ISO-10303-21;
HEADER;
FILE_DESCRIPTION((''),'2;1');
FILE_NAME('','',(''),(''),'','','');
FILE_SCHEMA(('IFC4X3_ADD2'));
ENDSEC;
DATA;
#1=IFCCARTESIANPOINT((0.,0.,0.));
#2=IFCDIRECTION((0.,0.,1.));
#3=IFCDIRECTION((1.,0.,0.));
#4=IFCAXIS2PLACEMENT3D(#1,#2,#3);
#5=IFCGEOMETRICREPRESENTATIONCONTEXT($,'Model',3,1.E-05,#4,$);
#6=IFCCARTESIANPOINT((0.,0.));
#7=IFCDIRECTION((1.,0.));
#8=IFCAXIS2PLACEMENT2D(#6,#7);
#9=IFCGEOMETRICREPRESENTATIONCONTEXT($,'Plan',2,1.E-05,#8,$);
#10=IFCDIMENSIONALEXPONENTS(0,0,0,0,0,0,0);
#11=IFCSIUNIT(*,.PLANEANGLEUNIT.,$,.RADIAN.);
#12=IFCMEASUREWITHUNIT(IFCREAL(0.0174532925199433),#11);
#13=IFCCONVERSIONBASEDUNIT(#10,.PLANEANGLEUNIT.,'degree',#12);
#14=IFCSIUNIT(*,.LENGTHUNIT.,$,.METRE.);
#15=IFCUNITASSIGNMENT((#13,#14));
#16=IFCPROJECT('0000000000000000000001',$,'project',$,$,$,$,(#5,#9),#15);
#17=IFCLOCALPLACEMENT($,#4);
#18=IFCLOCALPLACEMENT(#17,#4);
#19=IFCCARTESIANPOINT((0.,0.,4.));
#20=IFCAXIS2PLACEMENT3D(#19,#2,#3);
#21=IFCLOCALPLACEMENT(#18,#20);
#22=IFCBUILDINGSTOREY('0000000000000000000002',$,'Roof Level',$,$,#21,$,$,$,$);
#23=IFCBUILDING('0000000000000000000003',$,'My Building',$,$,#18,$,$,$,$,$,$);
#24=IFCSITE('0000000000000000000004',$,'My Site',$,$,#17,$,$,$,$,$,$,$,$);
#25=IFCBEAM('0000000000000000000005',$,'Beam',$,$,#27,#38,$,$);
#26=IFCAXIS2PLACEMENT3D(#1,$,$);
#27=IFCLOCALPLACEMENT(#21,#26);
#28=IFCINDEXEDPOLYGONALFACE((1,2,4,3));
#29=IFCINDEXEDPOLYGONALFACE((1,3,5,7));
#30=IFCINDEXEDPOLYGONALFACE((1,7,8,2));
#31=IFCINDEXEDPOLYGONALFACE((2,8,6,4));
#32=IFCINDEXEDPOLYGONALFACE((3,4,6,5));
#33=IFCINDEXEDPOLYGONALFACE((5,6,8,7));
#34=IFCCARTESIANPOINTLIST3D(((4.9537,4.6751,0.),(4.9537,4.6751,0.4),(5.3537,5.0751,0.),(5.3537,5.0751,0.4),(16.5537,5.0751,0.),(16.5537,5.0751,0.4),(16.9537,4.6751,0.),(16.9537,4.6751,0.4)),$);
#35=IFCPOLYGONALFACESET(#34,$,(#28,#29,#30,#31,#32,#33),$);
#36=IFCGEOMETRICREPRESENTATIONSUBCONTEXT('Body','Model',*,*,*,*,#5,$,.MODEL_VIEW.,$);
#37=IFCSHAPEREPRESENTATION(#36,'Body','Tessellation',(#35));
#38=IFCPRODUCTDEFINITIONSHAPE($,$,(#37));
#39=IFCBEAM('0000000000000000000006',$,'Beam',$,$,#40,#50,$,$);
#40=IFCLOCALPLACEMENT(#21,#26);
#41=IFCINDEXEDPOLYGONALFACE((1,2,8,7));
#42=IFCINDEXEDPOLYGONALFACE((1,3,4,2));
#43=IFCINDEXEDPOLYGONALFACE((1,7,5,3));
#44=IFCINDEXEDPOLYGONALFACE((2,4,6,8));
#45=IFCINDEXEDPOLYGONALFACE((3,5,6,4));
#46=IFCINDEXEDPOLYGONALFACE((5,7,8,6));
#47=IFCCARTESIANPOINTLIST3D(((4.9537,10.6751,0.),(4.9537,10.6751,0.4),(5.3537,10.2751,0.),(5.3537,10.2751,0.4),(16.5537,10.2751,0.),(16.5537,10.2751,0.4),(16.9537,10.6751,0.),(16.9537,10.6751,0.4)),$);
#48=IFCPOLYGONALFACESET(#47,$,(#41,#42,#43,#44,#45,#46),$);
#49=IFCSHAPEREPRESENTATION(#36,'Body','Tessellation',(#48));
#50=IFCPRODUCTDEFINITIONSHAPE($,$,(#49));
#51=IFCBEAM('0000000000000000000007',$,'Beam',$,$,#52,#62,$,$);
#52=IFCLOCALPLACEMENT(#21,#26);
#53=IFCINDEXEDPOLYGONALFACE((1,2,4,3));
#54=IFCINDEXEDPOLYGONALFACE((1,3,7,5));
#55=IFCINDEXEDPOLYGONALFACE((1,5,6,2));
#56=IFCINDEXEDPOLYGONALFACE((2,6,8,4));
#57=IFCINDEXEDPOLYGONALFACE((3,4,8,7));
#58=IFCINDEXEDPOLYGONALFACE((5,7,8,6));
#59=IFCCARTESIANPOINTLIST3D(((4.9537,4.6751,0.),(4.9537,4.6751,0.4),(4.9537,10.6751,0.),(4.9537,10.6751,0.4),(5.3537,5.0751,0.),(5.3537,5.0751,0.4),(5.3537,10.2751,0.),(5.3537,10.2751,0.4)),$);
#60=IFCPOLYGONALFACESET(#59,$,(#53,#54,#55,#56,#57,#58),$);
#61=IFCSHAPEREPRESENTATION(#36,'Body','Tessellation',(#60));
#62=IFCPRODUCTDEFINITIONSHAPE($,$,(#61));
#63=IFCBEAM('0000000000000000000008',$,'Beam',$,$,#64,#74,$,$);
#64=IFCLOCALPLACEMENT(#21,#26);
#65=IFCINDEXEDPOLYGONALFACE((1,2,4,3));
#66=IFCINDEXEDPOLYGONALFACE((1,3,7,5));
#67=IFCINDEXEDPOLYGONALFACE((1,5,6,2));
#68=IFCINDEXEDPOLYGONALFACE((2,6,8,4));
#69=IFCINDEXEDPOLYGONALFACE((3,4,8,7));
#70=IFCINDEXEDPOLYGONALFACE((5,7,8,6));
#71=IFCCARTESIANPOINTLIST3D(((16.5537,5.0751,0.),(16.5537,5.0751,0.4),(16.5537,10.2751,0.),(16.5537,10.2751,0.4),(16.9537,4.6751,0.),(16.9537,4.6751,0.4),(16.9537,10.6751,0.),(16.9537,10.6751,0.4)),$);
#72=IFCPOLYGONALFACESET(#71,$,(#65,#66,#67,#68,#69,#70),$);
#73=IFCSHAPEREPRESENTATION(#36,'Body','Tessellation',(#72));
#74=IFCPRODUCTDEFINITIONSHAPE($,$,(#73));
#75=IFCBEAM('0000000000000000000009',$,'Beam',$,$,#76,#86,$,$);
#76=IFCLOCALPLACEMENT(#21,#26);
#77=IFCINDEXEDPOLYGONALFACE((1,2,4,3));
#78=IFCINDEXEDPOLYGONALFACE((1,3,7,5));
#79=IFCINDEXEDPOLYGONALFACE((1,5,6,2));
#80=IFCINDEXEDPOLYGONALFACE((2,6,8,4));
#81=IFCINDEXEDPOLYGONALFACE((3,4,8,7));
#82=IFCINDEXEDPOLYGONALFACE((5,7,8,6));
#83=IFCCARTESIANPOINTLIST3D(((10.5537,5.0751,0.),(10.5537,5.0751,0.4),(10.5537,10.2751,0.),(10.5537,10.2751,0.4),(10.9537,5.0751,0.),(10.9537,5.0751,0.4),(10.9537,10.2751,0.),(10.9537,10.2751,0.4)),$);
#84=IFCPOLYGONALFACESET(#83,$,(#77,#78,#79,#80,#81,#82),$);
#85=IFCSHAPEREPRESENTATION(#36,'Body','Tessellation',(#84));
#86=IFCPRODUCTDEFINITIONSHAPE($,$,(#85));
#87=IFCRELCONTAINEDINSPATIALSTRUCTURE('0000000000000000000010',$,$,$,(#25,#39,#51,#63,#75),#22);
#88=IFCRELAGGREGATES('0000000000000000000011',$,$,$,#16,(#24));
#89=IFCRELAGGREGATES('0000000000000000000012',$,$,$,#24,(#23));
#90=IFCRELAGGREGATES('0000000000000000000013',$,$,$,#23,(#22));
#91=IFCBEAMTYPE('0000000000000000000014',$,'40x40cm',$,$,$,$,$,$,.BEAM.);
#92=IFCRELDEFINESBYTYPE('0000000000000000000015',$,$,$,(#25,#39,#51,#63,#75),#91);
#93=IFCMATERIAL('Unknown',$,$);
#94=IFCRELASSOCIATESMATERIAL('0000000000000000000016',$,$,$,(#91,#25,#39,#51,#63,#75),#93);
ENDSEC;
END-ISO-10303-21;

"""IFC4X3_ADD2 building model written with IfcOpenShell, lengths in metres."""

from ifc_helpers import new_model, entity, si_unit, converted_unit, frame, origin_with_axes, origin_2d_with_axis, place, context, subcontext, project, spatial, rectangle, extrude, clip, halfspace, material, material_profile, profile_set, profile_usage, type_object, element, save


model = new_model("IFC4X3_ADD2")

# Units and contexts
model_context = context("Model", 3, precision=1e-05, world=origin_with_axes())
plan_context = context("Plan", 2, precision=1e-05, world=origin_2d_with_axis())
body_context = subcontext(model_context, "Body", "Model", "MODEL_VIEW")
ifc_project = project(units=[converted_unit("PLANEANGLEUNIT", "degree", entity("IfcReal", 0.0174532925199433), si_unit("PLANEANGLEUNIT", "RADIAN"), dimensions=[0, 0, 0, 0, 0, 0, 0]), si_unit("LENGTHUNIT", "METRE")], contexts=[model_context, plan_context])

# Site, building, storey
site_placement = place(None, origin_with_axes())
site = spatial("IfcSite", under=ifc_project, at=site_placement, Name="My Site")
building_placement = place(site_placement, origin_with_axes())
building = spatial("IfcBuilding", under=site, at=building_placement, Name="My Building")
storey_placement = place(building_placement, frame((0.0, 0.0, 4.0), z_axis=(0.0, 0.0, 1.0), x_axis=(1.0, 0.0, 0.0)))
storey = spatial("IfcBuildingStorey", under=building, at=storey_placement, Name="Roof Level")

# Beams
ifc_material = material(Name="Unknown")
ifc_material_profile = material_profile(ifc_material, rectangle(XDim=0.4, YDim=0.4))
ifc_profile_set = profile_set([ifc_material_profile])
ifc_profile_usage_1 = profile_usage(ifc_profile_set, cardinal=5)
beam_type = type_object("IfcBeamType", Name="40x40cm", PredefinedType="BEAM", material=ifc_profile_set)
beam_1_placement = place(storey_placement, frame((4.9537, 4.8751, 0.2), z_axis=(1.0, 0.0, 0.0), x_axis=(0.0, 1.0, 0.0)))
element("IfcBeam", 1, at=beam_1_placement, inside=storey, type_object=beam_type, material=ifc_profile_usage_1, Name="Beam", context=body_context, shape_type="Clipping", body=[
    clip(clip(extrude(rectangle(XDim=0.4, YDim=0.4), origin_with_axes(), (0.0, 0.0, 1.0), 12.0), halfspace(frame((-0.2, -4.2, 12.0), z_axis=(0.707109, 0.0, 0.707105), x_axis=(0.0, -1.0, 0.0)), False)), halfspace(frame((-0.2, -4.2, 0.0), z_axis=(0.707107, 0.0, -0.707106), x_axis=(0.0, -1.0, 0.0)), False)),
])
ifc_profile_usage_2 = profile_usage(ifc_profile_set, cardinal=5)
beam_2_placement = place(storey_placement, frame((4.9537, 10.4751, 0.2), z_axis=(1.0, 0.0, 0.0), x_axis=(0.0, 1.0, 0.0)))
element("IfcBeam", 2, at=beam_2_placement, inside=storey, type_object=beam_type, material=ifc_profile_usage_2, Name="Beam", context=body_context, shape_type="Clipping", body=[
    clip(clip(extrude(rectangle(XDim=0.4, YDim=0.4), origin_with_axes(), (0.0, 0.0, 1.0), 12.0), halfspace(frame((0.2, -4.2, 12.0), z_axis=(-0.70711, 0.0, 0.707103), x_axis=(0.0, 1.0, 0.0)), False)), halfspace(frame((0.2, -4.2, 0.0), z_axis=(-0.707107, 0.0, -0.707107), x_axis=(0.0, 1.0, 0.0)), False)),
])
ifc_profile_usage_3 = profile_usage(ifc_profile_set, cardinal=5)
beam_3_placement = place(storey_placement, frame((5.1537, 4.6751, 0.2), z_axis=(0.0, 1.0, 0.0), x_axis=(-1.0, 0.0, 0.0)))
element("IfcBeam", 3, at=beam_3_placement, inside=storey, type_object=beam_type, material=ifc_profile_usage_3, Name="Beam", context=body_context, shape_type="Clipping", body=[
    clip(clip(extrude(rectangle(XDim=0.4, YDim=0.4), origin_with_axes(), (0.0, 0.0, 1.0), 6.0), halfspace(frame((0.2, -4.2, 0.0), z_axis=(-0.707107, 0.0, -0.707107), x_axis=(0.0, 1.0, 0.0)), False)), halfspace(frame((0.2, -4.2, 6.0), z_axis=(-0.707107, 0.0, 0.707107), x_axis=(0.0, 1.0, 0.0)), False)),
])
ifc_profile_usage_4 = profile_usage(ifc_profile_set, cardinal=5)
beam_4_placement = place(storey_placement, frame((16.7537, 4.6751, 0.2), z_axis=(0.0, 1.0, 0.0), x_axis=(-1.0, 0.0, 0.0)))
element("IfcBeam", 4, at=beam_4_placement, inside=storey, type_object=beam_type, material=ifc_profile_usage_4, Name="Beam", context=body_context, shape_type="Clipping", body=[
    clip(clip(extrude(rectangle(XDim=0.4, YDim=0.4), origin_with_axes(), (0.0, 0.0, 1.0), 6.0), halfspace(frame((-0.2, -4.2, 6.0), z_axis=(0.707104, 0.0, 0.70711), x_axis=(0.0, -1.0, 0.0)), False)), halfspace(frame((-0.2, -4.2, 0.0), z_axis=(0.707105, 0.0, -0.707109), x_axis=(0.0, -1.0, 0.0)), False)),
])
ifc_profile_usage_5 = profile_usage(ifc_profile_set, cardinal=5)
beam_5_placement = place(storey_placement, frame((10.7537, 5.0751, 0.2), z_axis=(0.0, 1.0, 0.0), x_axis=(-1.0, 0.0, 0.0)))
element("IfcBeam", 5, at=beam_5_placement, inside=storey, type_object=beam_type, material=ifc_profile_usage_5, Name="Beam", context=body_context, shape_type="SweptSolid", body=[
    extrude(rectangle(XDim=0.4, YDim=0.4), origin_with_axes(), (0.0, 0.0, 1.0), 5.2),
])

save(model, "model.ifc")
